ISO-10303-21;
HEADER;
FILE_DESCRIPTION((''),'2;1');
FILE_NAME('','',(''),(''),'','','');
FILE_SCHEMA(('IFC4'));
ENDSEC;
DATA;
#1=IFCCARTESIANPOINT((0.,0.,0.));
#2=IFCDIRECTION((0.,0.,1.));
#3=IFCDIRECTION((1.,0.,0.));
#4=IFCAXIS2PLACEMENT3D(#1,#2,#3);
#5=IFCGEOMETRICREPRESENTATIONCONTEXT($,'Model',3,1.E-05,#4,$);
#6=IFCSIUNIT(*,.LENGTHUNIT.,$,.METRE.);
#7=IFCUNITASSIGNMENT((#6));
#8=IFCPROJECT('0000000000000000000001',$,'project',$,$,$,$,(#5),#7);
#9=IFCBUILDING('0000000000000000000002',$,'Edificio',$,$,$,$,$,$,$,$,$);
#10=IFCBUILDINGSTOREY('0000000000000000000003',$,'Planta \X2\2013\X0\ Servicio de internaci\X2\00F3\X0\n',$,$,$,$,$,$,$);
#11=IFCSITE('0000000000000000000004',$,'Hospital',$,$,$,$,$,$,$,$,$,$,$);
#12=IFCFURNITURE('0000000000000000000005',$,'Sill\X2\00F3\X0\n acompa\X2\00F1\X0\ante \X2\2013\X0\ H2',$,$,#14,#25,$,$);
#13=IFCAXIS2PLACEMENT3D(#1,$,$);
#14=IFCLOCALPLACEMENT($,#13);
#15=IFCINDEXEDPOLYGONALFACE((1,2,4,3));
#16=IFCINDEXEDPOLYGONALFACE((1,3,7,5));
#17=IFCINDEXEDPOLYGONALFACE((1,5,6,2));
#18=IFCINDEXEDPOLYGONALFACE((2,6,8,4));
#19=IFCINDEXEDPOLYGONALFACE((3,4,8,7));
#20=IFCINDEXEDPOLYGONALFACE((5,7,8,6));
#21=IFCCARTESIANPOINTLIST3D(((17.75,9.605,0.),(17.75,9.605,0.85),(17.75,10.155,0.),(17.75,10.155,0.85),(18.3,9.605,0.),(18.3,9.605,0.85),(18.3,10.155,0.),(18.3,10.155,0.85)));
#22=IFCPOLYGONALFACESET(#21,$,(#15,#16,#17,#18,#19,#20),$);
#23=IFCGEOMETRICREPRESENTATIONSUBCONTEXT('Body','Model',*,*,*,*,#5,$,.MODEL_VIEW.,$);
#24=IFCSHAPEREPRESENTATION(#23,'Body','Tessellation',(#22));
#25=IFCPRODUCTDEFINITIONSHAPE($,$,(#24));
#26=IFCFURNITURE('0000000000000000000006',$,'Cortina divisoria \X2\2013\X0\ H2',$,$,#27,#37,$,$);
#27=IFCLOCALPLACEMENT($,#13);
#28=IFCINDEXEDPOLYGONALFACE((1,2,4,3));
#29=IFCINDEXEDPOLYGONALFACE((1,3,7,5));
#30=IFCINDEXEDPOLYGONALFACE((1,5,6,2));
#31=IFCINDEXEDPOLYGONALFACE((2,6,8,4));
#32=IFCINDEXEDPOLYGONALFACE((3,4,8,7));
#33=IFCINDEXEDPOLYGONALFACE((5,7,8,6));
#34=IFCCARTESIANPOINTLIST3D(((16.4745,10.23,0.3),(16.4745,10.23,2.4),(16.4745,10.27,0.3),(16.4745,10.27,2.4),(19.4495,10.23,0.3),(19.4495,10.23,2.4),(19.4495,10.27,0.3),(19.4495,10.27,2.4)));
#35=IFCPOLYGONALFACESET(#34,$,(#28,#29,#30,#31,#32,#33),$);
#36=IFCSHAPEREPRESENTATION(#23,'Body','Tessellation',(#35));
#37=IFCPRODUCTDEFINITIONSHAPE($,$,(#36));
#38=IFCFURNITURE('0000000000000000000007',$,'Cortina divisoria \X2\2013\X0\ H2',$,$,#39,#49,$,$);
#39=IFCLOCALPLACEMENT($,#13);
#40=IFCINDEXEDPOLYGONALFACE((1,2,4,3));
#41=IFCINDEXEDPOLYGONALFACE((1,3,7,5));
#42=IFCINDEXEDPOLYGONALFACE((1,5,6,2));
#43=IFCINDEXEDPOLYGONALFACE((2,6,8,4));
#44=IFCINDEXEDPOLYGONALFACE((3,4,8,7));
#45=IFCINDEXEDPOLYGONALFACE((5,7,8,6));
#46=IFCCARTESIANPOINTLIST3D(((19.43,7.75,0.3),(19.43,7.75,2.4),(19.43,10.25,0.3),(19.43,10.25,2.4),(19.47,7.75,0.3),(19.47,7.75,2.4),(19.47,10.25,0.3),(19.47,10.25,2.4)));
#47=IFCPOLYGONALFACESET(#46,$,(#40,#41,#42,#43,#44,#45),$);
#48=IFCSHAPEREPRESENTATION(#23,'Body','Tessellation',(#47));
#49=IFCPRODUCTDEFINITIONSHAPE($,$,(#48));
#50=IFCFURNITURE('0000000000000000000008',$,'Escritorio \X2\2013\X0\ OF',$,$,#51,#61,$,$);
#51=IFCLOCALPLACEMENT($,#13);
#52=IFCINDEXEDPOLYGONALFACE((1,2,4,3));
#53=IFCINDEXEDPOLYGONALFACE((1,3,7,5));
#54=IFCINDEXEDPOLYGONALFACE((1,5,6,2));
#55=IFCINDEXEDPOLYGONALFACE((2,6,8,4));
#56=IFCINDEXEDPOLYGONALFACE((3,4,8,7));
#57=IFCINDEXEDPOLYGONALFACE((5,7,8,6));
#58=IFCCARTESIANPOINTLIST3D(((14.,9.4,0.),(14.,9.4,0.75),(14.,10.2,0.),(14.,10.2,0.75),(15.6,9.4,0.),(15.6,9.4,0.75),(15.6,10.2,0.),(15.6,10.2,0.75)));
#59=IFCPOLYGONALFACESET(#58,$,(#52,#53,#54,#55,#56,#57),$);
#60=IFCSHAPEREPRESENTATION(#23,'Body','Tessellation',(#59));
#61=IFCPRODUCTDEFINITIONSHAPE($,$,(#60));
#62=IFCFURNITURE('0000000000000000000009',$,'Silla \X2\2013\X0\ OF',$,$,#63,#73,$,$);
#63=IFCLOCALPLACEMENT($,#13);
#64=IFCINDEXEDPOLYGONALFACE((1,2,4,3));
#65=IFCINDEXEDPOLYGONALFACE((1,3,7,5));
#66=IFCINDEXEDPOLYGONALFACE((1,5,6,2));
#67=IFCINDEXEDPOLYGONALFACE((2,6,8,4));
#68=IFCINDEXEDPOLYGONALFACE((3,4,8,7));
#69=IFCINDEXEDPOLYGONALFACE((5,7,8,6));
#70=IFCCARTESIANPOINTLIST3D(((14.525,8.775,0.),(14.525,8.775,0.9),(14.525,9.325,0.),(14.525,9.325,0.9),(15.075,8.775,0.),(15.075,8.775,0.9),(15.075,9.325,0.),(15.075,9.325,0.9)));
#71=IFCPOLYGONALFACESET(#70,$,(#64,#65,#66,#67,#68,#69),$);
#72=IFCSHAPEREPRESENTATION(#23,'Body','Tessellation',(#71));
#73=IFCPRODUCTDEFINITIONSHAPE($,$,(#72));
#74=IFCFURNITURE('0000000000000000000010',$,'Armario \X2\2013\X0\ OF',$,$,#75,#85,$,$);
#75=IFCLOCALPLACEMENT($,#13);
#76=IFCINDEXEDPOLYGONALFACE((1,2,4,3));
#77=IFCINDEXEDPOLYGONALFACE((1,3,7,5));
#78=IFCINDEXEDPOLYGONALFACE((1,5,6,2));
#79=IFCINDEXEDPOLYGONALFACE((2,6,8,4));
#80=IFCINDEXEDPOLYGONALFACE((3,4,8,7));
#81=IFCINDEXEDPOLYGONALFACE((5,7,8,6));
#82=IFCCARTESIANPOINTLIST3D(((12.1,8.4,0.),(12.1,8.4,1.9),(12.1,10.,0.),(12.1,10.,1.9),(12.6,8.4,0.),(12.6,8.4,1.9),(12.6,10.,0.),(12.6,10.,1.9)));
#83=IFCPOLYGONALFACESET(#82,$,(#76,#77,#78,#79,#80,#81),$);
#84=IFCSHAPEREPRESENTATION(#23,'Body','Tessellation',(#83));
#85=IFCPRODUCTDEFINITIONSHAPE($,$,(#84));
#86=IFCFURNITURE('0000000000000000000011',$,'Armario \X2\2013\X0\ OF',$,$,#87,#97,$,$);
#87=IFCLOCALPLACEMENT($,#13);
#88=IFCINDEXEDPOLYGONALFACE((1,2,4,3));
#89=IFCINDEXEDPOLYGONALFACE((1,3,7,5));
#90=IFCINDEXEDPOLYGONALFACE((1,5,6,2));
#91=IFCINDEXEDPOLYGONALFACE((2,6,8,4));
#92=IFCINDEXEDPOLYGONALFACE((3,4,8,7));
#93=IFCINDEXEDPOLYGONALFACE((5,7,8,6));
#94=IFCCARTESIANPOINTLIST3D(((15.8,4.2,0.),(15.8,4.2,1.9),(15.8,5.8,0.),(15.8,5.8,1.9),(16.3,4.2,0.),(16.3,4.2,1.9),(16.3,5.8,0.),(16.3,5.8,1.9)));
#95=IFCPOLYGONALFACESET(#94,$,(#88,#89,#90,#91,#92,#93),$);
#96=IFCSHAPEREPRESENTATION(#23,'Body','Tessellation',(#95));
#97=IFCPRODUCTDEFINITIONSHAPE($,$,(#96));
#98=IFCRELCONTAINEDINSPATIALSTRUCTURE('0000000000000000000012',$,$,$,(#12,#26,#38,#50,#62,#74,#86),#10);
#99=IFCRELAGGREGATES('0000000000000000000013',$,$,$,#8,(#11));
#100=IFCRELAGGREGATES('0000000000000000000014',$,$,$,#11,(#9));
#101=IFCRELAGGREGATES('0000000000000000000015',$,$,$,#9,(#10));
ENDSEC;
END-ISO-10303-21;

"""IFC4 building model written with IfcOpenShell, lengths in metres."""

from ifc_helpers import new_model, si_unit, frame, origin_with_axes, context, subcontext, project, spatial, line, indexed_curve, outline, extrude, element, save


model = new_model("IFC4")

# Units and contexts
model_context = context("Model", 3, precision=1e-05, world=origin_with_axes())
body_context = subcontext(model_context, "Body", "Model", "MODEL_VIEW")
ifc_project = project(units=[si_unit("LENGTHUNIT", "METRE")], contexts=[model_context])

# Site, building, storey
site = spatial("IfcSite", under=ifc_project, Name="Hospital")
building = spatial("IfcBuilding", under=site, Name="Edificio")
storey = spatial("IfcBuildingStorey", under=building, Name="Planta – Servicio de internación")

# Furniture
element("IfcFurniture", 1, inside=storey, Name="Sillón acompañante – H2", context=body_context, shape_type="SweptSolid", body=[
    extrude(outline(indexed_curve([(0.0, 0.0), (0.55, 0.0), (0.55, 0.55), (0.0, 0.55)], segments=[line(1, 2, 3, 4, 1)])), frame((17.75, 9.605, 0.0), z_axis=(0.0, 0.0, 1.0), x_axis=(1.0, 0.0, 0.0)), (0.0, 0.0, 1.0), 0.85),
])
element("IfcFurniture", 2, inside=storey, Name="Cortina divisoria – H2", context=body_context, shape_type="SweptSolid", body=[
    extrude(outline(indexed_curve([(0.0, 0.0), (2.975, 0.0), (2.975, 0.04), (0.0, 0.04)], segments=[line(1, 2, 3, 4, 1)])), frame((16.4745, 10.23, 0.3), z_axis=(0.0, 0.0, 1.0), x_axis=(1.0, 0.0, 0.0)), (0.0, 0.0, 1.0), 2.1),
])
element("IfcFurniture", 3, inside=storey, Name="Cortina divisoria – H2", context=body_context, shape_type="SweptSolid", body=[
    extrude(outline(indexed_curve([(0.0, 0.0), (0.04, 0.0), (0.04, 2.5), (0.0, 2.5)], segments=[line(1, 2, 3, 4, 1)])), frame((19.43, 7.75, 0.3), z_axis=(0.0, 0.0, 1.0), x_axis=(1.0, 0.0, 0.0)), (0.0, 0.0, 1.0), 2.1),
])
element("IfcFurniture", 4, inside=storey, Name="Escritorio – OF", context=body_context, shape_type="SweptSolid", body=[
    extrude(outline(indexed_curve([(0.0, 0.0), (1.6, 0.0), (1.6, 0.8), (0.0, 0.8)], segments=[line(1, 2, 3, 4, 1)])), frame((14.0, 9.4, 0.0), z_axis=(0.0, 0.0, 1.0), x_axis=(1.0, 0.0, 0.0)), (0.0, 0.0, 1.0), 0.75),
])
element("IfcFurniture", 5, inside=storey, Name="Silla – OF", context=body_context, shape_type="SweptSolid", body=[
    extrude(outline(indexed_curve([(0.0, 0.0), (0.55, 0.0), (0.55, 0.55), (0.0, 0.55)], segments=[line(1, 2, 3, 4, 1)])), frame((14.525, 8.775, 0.0), z_axis=(0.0, 0.0, 1.0), x_axis=(1.0, 0.0, 0.0)), (0.0, 0.0, 1.0), 0.9),
])
element("IfcFurniture", 6, inside=storey, Name="Armario – OF", context=body_context, shape_type="SweptSolid", body=[
    extrude(outline(indexed_curve([(0.0, 0.0), (0.5, 0.0), (0.5, 1.6), (0.0, 1.6)], segments=[line(1, 2, 3, 4, 1)])), frame((12.1, 8.4, 0.0), z_axis=(0.0, 0.0, 1.0), x_axis=(1.0, 0.0, 0.0)), (0.0, 0.0, 1.0), 1.9),
])
element("IfcFurniture", 7, inside=storey, Name="Armario – OF", context=body_context, shape_type="SweptSolid", body=[
    extrude(outline(indexed_curve([(0.0, 0.0), (0.5, 0.0), (0.5, 1.6), (0.0, 1.6)], segments=[line(1, 2, 3, 4, 1)])), frame((15.8, 4.2, 0.0), z_axis=(0.0, 0.0, 1.0), x_axis=(1.0, 0.0, 0.0)), (0.0, 0.0, 1.0), 1.9),
])

save(model, "model.ifc")
